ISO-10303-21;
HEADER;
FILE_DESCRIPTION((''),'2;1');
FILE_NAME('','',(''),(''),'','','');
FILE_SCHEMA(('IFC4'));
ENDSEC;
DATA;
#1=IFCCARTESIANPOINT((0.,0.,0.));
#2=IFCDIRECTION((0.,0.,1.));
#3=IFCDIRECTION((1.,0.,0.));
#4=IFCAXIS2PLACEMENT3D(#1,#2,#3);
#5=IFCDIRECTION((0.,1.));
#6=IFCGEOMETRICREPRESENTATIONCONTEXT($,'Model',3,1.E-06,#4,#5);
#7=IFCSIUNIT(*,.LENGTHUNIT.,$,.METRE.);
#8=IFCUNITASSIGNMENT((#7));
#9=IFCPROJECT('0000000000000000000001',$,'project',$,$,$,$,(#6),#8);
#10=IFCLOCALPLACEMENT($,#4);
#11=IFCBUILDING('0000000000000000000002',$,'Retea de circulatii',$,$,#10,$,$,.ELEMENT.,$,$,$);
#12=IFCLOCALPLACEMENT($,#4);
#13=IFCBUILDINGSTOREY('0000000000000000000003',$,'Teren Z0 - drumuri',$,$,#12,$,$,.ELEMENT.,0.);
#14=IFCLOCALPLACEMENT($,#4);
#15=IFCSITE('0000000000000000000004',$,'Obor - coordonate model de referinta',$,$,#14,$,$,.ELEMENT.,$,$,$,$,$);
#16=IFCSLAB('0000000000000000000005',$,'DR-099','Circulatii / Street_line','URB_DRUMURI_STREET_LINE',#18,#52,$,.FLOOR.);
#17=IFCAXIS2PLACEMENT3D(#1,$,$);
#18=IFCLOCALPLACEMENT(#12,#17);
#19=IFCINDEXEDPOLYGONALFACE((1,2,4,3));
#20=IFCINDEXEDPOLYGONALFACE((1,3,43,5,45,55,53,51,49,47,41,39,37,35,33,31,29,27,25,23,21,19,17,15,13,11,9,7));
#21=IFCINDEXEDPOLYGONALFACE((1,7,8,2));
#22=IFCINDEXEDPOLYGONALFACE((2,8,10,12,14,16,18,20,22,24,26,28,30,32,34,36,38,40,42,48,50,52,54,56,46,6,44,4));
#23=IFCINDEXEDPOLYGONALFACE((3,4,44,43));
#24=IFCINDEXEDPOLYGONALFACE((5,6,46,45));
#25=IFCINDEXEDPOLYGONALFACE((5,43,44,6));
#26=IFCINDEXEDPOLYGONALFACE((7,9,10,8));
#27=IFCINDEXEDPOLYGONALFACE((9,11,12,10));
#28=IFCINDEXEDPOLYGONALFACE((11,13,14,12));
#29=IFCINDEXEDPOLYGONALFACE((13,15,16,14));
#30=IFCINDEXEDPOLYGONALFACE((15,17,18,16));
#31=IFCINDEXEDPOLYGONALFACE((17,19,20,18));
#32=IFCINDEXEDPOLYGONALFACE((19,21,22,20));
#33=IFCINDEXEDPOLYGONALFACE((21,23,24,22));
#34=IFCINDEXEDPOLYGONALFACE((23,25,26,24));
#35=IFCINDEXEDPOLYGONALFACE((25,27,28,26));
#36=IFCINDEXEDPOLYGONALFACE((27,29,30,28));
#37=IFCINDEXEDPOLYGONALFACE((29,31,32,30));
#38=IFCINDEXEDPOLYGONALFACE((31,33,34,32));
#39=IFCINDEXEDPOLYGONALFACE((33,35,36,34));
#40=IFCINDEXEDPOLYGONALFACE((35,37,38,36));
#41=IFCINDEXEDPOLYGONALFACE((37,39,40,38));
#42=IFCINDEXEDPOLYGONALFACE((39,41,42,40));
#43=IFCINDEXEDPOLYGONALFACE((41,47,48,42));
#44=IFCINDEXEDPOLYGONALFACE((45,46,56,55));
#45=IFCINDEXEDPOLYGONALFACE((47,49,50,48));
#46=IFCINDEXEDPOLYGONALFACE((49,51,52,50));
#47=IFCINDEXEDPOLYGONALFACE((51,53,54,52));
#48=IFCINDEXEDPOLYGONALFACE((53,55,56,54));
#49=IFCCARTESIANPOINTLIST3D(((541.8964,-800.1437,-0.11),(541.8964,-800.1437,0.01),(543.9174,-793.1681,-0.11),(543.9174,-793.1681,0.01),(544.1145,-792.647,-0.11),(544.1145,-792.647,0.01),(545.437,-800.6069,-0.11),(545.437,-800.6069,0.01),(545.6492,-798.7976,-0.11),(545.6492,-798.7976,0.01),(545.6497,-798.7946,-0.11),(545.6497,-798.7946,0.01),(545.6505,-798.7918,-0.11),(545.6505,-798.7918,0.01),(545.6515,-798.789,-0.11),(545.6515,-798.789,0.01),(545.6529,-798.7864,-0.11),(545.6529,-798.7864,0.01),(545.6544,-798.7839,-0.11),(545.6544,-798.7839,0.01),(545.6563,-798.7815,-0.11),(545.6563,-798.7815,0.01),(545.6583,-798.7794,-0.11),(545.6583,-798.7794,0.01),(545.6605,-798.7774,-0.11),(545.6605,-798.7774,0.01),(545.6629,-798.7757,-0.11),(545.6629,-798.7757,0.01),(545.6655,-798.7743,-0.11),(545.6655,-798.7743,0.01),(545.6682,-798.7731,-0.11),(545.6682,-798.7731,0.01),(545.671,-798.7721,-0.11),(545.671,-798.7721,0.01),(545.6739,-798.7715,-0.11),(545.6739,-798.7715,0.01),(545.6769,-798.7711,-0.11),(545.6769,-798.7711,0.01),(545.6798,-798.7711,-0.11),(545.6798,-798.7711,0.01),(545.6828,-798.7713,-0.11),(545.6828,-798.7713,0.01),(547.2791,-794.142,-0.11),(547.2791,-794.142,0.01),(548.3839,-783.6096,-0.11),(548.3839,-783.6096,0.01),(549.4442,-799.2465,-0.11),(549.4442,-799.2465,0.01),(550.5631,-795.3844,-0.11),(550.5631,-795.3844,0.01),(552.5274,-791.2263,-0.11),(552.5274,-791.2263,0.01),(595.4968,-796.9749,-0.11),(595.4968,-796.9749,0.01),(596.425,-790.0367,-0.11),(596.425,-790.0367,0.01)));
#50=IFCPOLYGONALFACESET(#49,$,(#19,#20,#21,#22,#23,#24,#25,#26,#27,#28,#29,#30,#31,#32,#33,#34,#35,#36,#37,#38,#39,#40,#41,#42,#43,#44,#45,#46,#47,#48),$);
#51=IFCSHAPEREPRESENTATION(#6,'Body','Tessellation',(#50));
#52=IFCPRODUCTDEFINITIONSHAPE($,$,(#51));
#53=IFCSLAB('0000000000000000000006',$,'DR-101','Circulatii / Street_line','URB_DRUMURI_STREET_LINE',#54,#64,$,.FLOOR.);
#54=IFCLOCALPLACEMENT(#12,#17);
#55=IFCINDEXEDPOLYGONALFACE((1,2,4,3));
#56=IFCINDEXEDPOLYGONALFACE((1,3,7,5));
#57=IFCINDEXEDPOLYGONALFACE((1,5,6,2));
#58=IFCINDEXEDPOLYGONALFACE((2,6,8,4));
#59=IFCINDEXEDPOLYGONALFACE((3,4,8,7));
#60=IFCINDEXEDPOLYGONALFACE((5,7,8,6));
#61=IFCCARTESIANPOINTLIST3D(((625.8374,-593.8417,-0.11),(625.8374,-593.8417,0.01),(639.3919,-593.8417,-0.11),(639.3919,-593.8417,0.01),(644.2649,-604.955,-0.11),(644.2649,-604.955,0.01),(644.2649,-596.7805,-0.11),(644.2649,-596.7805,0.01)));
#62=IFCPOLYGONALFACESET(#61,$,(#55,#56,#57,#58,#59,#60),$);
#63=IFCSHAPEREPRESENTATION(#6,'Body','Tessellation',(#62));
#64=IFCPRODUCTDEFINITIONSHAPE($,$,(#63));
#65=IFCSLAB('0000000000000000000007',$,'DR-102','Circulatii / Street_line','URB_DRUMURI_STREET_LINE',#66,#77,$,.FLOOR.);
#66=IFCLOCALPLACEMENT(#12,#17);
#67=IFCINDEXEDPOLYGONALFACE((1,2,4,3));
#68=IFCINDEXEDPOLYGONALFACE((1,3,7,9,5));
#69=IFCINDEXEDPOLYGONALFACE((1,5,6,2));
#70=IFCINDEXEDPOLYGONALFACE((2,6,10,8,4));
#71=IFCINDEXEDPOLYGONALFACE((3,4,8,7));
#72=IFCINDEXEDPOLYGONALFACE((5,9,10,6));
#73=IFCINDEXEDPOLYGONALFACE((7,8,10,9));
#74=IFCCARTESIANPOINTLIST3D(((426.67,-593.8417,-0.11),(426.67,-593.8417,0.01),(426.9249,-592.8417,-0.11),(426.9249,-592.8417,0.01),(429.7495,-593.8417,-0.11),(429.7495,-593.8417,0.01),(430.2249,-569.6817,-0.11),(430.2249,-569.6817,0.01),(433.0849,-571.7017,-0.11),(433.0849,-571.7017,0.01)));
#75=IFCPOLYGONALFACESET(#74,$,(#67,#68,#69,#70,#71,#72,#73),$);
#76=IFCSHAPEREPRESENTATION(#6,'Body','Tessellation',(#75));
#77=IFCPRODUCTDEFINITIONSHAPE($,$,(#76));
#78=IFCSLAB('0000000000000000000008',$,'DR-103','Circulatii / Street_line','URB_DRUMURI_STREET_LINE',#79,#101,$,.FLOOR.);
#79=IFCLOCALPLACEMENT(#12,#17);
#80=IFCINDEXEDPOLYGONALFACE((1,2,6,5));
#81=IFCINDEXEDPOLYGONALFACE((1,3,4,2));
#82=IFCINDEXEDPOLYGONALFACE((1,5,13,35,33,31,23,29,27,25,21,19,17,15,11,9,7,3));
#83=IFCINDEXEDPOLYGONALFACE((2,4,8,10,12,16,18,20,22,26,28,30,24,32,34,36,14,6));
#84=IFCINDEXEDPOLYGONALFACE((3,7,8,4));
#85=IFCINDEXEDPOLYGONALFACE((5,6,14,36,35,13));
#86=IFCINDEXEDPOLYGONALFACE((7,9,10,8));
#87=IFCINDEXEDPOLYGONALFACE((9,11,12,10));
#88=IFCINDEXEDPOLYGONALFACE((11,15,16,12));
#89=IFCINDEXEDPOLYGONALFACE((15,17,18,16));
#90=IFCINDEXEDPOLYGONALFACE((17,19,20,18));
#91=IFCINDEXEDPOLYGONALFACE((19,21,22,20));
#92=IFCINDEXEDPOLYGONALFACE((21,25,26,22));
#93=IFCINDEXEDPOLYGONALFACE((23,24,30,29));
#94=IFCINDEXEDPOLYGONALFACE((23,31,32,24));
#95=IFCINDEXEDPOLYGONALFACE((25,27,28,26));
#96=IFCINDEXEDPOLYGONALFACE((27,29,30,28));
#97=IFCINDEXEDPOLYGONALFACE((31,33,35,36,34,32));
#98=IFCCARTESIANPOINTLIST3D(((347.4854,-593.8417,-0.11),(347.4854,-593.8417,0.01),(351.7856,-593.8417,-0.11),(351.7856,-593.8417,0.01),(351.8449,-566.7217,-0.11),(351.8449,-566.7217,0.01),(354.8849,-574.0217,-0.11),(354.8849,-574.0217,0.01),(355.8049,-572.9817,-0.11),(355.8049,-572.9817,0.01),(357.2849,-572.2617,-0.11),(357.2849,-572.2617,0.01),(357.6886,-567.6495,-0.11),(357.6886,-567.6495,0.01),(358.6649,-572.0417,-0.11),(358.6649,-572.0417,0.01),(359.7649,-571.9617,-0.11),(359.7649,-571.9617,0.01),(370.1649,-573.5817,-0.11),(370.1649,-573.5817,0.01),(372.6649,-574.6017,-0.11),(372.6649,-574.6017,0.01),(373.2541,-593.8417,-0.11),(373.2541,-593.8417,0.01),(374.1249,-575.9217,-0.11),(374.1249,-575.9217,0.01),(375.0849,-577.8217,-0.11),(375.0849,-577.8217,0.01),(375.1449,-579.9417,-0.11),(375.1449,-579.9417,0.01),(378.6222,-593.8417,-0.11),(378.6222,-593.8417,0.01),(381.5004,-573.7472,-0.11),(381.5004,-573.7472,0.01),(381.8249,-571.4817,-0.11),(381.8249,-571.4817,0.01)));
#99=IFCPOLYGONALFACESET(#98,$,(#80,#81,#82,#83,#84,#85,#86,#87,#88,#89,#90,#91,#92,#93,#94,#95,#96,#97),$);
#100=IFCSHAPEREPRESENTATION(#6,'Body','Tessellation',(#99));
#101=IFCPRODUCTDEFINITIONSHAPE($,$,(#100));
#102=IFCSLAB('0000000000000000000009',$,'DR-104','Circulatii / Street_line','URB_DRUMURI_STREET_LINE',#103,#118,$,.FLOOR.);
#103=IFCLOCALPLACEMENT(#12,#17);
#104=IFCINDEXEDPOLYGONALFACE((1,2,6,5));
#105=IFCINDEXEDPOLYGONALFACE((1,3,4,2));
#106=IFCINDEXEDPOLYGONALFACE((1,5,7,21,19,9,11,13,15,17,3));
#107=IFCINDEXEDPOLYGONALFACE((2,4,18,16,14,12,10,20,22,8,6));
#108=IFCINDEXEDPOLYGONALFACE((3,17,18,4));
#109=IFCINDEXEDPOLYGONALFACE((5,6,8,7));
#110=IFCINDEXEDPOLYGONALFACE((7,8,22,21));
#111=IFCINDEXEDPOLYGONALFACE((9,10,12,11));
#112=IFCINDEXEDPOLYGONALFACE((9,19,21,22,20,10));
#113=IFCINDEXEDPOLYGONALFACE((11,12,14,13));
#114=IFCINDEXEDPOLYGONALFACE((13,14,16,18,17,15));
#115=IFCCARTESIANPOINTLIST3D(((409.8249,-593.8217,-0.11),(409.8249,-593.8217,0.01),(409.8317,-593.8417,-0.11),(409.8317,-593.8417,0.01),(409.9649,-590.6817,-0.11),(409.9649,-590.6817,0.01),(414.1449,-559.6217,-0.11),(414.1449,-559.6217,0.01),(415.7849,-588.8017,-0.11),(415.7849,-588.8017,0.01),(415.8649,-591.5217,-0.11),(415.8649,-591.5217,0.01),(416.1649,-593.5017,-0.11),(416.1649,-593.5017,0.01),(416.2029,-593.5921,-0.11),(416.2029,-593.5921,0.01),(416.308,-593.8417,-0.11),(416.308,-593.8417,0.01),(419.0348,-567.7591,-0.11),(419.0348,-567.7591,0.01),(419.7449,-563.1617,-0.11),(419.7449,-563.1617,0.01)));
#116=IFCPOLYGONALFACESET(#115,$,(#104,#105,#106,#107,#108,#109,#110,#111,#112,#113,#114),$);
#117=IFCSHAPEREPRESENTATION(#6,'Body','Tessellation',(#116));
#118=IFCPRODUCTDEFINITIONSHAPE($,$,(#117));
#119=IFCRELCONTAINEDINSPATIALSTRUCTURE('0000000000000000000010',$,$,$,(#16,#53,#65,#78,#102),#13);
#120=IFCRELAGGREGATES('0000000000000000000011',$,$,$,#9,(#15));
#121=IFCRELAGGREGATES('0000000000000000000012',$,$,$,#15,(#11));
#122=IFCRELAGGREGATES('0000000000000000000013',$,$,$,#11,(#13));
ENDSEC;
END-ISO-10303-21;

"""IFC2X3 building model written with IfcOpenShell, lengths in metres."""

from ifc_helpers import new_model, si_unit, direction, frame, origin_with_axes, place, context, project, spatial, polyline, outline, extrude, element, save


model = new_model("IFC2X3")

# Units and contexts
model_context = context("Model", 3, precision=1e-06, world=origin_with_axes(), true_north=direction((0.0, 1.0)))
ifc_project = project(units=[si_unit("LENGTHUNIT", "METRE")], contexts=[model_context])

# Site, building, storey
site_placement = place(None, origin_with_axes())
site = spatial("IfcSite", under=ifc_project, at=site_placement, Name="Obor - coordonate model de referinta", CompositionType="ELEMENT")
building_placement = place(None, origin_with_axes())
building = spatial("IfcBuilding", under=site, at=building_placement, Name="Retea de circulatii", CompositionType="ELEMENT")
storey_placement = place(None, origin_with_axes())
storey = spatial("IfcBuildingStorey", under=building, at=storey_placement, Name="Teren Z0 - drumuri", CompositionType="ELEMENT", Elevation=0.0)

# Slabs
slab_1_placement = place(None, origin_with_axes())
element("IfcSlab", 1, at=slab_1_placement, inside=storey, Name="DR-099", Description="Circulatii / Street_line", ObjectType="URB_DRUMURI_STREET_LINE", PredefinedType="FLOOR", context=model_context, shape_type="SweptSolid", body=[
    extrude(outline(polyline([(545.437, -800.6069), (545.6492, -798.7976), (545.6497, -798.7946), (545.6505, -798.7918), (545.6515, -798.789), (545.6529, -798.7864), (545.6544, -798.7839), (545.6563, -798.7815), (545.6583, -798.7794), (545.6605, -798.7774), (545.6629, -798.7757), (545.6655, -798.7743), (545.6682, -798.7731), (545.671, -798.7721), (545.6739, -798.7715), (545.6769, -798.7711), (545.6798, -798.7711), (545.6828, -798.7713), (549.4442, -799.2465), (550.5631, -795.3844), (552.5274, -791.2263), (595.4968, -796.9749), (596.425, -790.0367), (548.3839, -783.6096), (544.1145, -792.647), (547.2791, -794.142), (543.9174, -793.1681), (541.8964, -800.1437), (545.437, -800.6069)])), frame((0.0, 0.0, -0.11), z_axis=(0.0, 0.0, 1.0), x_axis=(1.0, 0.0, 0.0)), (0.0, 0.0, 1.0), 0.12),
])
slab_2_placement = place(None, origin_with_axes())
element("IfcSlab", 2, at=slab_2_placement, inside=storey, Name="DR-101", Description="Circulatii / Street_line", ObjectType="URB_DRUMURI_STREET_LINE", PredefinedType="FLOOR", context=model_context, shape_type="SweptSolid", body=[
    extrude(outline(polyline([(644.2649, -596.7805), (639.3919, -593.8417), (625.8374, -593.8417), (644.2649, -604.955), (644.2649, -596.7805)])), frame((0.0, 0.0, -0.11), z_axis=(0.0, 0.0, 1.0), x_axis=(1.0, 0.0, 0.0)), (0.0, 0.0, 1.0), 0.12),
])
slab_3_placement = place(None, origin_with_axes())
element("IfcSlab", 3, at=slab_3_placement, inside=storey, Name="DR-102", Description="Circulatii / Street_line", ObjectType="URB_DRUMURI_STREET_LINE", PredefinedType="FLOOR", context=model_context, shape_type="SweptSolid", body=[
    extrude(outline(polyline([(433.0849, -571.7017), (430.2249, -569.6817), (426.9249, -592.8417), (426.67, -593.8417), (429.7495, -593.8417), (433.0849, -571.7017)])), frame((0.0, 0.0, -0.11), z_axis=(0.0, 0.0, 1.0), x_axis=(1.0, 0.0, 0.0)), (0.0, 0.0, 1.0), 0.12),
])
slab_4_placement = place(None, origin_with_axes())
element("IfcSlab", 4, at=slab_4_placement, inside=storey, Name="DR-103", Description="Circulatii / Street_line", ObjectType="URB_DRUMURI_STREET_LINE", PredefinedType="FLOOR", context=model_context, shape_type="SweptSolid", body=[
    extrude(outline(polyline([(381.5004, -573.7472), (381.8249, -571.4817), (357.6886, -567.6495), (351.8449, -566.7217), (347.4854, -593.8417), (351.7856, -593.8417), (354.8849, -574.0217), (355.8049, -572.9817), (357.2849, -572.2617), (358.6649, -572.0417), (359.7649, -571.9617), (370.1649, -573.5817), (372.6649, -574.6017), (374.1249, -575.9217), (375.0849, -577.8217), (375.1449, -579.9417), (373.2541, -593.8417), (378.6222, -593.8417), (381.5004, -573.7472)])), frame((0.0, 0.0, -0.11), z_axis=(0.0, 0.0, 1.0), x_axis=(1.0, 0.0, 0.0)), (0.0, 0.0, 1.0), 0.12),
])
slab_5_placement = place(None, origin_with_axes())
element("IfcSlab", 5, at=slab_5_placement, inside=storey, Name="DR-104", Description="Circulatii / Street_line", ObjectType="URB_DRUMURI_STREET_LINE", PredefinedType="FLOOR", context=model_context, shape_type="SweptSolid", body=[
    extrude(outline(polyline([(419.7449, -563.1617), (414.1449, -559.6217), (409.9649, -590.6817), (409.8249, -593.8217), (409.8317, -593.8417), (416.308, -593.8417), (416.2029, -593.5921), (416.1649, -593.5017), (415.8649, -591.5217), (415.7849, -588.8017), (419.0348, -567.7591), (419.7449, -563.1617)])), frame((0.0, 0.0, -0.11), z_axis=(0.0, 0.0, 1.0), x_axis=(1.0, 0.0, 0.0)), (0.0, 0.0, 1.0), 0.12),
])

save(model, "model.ifc")
